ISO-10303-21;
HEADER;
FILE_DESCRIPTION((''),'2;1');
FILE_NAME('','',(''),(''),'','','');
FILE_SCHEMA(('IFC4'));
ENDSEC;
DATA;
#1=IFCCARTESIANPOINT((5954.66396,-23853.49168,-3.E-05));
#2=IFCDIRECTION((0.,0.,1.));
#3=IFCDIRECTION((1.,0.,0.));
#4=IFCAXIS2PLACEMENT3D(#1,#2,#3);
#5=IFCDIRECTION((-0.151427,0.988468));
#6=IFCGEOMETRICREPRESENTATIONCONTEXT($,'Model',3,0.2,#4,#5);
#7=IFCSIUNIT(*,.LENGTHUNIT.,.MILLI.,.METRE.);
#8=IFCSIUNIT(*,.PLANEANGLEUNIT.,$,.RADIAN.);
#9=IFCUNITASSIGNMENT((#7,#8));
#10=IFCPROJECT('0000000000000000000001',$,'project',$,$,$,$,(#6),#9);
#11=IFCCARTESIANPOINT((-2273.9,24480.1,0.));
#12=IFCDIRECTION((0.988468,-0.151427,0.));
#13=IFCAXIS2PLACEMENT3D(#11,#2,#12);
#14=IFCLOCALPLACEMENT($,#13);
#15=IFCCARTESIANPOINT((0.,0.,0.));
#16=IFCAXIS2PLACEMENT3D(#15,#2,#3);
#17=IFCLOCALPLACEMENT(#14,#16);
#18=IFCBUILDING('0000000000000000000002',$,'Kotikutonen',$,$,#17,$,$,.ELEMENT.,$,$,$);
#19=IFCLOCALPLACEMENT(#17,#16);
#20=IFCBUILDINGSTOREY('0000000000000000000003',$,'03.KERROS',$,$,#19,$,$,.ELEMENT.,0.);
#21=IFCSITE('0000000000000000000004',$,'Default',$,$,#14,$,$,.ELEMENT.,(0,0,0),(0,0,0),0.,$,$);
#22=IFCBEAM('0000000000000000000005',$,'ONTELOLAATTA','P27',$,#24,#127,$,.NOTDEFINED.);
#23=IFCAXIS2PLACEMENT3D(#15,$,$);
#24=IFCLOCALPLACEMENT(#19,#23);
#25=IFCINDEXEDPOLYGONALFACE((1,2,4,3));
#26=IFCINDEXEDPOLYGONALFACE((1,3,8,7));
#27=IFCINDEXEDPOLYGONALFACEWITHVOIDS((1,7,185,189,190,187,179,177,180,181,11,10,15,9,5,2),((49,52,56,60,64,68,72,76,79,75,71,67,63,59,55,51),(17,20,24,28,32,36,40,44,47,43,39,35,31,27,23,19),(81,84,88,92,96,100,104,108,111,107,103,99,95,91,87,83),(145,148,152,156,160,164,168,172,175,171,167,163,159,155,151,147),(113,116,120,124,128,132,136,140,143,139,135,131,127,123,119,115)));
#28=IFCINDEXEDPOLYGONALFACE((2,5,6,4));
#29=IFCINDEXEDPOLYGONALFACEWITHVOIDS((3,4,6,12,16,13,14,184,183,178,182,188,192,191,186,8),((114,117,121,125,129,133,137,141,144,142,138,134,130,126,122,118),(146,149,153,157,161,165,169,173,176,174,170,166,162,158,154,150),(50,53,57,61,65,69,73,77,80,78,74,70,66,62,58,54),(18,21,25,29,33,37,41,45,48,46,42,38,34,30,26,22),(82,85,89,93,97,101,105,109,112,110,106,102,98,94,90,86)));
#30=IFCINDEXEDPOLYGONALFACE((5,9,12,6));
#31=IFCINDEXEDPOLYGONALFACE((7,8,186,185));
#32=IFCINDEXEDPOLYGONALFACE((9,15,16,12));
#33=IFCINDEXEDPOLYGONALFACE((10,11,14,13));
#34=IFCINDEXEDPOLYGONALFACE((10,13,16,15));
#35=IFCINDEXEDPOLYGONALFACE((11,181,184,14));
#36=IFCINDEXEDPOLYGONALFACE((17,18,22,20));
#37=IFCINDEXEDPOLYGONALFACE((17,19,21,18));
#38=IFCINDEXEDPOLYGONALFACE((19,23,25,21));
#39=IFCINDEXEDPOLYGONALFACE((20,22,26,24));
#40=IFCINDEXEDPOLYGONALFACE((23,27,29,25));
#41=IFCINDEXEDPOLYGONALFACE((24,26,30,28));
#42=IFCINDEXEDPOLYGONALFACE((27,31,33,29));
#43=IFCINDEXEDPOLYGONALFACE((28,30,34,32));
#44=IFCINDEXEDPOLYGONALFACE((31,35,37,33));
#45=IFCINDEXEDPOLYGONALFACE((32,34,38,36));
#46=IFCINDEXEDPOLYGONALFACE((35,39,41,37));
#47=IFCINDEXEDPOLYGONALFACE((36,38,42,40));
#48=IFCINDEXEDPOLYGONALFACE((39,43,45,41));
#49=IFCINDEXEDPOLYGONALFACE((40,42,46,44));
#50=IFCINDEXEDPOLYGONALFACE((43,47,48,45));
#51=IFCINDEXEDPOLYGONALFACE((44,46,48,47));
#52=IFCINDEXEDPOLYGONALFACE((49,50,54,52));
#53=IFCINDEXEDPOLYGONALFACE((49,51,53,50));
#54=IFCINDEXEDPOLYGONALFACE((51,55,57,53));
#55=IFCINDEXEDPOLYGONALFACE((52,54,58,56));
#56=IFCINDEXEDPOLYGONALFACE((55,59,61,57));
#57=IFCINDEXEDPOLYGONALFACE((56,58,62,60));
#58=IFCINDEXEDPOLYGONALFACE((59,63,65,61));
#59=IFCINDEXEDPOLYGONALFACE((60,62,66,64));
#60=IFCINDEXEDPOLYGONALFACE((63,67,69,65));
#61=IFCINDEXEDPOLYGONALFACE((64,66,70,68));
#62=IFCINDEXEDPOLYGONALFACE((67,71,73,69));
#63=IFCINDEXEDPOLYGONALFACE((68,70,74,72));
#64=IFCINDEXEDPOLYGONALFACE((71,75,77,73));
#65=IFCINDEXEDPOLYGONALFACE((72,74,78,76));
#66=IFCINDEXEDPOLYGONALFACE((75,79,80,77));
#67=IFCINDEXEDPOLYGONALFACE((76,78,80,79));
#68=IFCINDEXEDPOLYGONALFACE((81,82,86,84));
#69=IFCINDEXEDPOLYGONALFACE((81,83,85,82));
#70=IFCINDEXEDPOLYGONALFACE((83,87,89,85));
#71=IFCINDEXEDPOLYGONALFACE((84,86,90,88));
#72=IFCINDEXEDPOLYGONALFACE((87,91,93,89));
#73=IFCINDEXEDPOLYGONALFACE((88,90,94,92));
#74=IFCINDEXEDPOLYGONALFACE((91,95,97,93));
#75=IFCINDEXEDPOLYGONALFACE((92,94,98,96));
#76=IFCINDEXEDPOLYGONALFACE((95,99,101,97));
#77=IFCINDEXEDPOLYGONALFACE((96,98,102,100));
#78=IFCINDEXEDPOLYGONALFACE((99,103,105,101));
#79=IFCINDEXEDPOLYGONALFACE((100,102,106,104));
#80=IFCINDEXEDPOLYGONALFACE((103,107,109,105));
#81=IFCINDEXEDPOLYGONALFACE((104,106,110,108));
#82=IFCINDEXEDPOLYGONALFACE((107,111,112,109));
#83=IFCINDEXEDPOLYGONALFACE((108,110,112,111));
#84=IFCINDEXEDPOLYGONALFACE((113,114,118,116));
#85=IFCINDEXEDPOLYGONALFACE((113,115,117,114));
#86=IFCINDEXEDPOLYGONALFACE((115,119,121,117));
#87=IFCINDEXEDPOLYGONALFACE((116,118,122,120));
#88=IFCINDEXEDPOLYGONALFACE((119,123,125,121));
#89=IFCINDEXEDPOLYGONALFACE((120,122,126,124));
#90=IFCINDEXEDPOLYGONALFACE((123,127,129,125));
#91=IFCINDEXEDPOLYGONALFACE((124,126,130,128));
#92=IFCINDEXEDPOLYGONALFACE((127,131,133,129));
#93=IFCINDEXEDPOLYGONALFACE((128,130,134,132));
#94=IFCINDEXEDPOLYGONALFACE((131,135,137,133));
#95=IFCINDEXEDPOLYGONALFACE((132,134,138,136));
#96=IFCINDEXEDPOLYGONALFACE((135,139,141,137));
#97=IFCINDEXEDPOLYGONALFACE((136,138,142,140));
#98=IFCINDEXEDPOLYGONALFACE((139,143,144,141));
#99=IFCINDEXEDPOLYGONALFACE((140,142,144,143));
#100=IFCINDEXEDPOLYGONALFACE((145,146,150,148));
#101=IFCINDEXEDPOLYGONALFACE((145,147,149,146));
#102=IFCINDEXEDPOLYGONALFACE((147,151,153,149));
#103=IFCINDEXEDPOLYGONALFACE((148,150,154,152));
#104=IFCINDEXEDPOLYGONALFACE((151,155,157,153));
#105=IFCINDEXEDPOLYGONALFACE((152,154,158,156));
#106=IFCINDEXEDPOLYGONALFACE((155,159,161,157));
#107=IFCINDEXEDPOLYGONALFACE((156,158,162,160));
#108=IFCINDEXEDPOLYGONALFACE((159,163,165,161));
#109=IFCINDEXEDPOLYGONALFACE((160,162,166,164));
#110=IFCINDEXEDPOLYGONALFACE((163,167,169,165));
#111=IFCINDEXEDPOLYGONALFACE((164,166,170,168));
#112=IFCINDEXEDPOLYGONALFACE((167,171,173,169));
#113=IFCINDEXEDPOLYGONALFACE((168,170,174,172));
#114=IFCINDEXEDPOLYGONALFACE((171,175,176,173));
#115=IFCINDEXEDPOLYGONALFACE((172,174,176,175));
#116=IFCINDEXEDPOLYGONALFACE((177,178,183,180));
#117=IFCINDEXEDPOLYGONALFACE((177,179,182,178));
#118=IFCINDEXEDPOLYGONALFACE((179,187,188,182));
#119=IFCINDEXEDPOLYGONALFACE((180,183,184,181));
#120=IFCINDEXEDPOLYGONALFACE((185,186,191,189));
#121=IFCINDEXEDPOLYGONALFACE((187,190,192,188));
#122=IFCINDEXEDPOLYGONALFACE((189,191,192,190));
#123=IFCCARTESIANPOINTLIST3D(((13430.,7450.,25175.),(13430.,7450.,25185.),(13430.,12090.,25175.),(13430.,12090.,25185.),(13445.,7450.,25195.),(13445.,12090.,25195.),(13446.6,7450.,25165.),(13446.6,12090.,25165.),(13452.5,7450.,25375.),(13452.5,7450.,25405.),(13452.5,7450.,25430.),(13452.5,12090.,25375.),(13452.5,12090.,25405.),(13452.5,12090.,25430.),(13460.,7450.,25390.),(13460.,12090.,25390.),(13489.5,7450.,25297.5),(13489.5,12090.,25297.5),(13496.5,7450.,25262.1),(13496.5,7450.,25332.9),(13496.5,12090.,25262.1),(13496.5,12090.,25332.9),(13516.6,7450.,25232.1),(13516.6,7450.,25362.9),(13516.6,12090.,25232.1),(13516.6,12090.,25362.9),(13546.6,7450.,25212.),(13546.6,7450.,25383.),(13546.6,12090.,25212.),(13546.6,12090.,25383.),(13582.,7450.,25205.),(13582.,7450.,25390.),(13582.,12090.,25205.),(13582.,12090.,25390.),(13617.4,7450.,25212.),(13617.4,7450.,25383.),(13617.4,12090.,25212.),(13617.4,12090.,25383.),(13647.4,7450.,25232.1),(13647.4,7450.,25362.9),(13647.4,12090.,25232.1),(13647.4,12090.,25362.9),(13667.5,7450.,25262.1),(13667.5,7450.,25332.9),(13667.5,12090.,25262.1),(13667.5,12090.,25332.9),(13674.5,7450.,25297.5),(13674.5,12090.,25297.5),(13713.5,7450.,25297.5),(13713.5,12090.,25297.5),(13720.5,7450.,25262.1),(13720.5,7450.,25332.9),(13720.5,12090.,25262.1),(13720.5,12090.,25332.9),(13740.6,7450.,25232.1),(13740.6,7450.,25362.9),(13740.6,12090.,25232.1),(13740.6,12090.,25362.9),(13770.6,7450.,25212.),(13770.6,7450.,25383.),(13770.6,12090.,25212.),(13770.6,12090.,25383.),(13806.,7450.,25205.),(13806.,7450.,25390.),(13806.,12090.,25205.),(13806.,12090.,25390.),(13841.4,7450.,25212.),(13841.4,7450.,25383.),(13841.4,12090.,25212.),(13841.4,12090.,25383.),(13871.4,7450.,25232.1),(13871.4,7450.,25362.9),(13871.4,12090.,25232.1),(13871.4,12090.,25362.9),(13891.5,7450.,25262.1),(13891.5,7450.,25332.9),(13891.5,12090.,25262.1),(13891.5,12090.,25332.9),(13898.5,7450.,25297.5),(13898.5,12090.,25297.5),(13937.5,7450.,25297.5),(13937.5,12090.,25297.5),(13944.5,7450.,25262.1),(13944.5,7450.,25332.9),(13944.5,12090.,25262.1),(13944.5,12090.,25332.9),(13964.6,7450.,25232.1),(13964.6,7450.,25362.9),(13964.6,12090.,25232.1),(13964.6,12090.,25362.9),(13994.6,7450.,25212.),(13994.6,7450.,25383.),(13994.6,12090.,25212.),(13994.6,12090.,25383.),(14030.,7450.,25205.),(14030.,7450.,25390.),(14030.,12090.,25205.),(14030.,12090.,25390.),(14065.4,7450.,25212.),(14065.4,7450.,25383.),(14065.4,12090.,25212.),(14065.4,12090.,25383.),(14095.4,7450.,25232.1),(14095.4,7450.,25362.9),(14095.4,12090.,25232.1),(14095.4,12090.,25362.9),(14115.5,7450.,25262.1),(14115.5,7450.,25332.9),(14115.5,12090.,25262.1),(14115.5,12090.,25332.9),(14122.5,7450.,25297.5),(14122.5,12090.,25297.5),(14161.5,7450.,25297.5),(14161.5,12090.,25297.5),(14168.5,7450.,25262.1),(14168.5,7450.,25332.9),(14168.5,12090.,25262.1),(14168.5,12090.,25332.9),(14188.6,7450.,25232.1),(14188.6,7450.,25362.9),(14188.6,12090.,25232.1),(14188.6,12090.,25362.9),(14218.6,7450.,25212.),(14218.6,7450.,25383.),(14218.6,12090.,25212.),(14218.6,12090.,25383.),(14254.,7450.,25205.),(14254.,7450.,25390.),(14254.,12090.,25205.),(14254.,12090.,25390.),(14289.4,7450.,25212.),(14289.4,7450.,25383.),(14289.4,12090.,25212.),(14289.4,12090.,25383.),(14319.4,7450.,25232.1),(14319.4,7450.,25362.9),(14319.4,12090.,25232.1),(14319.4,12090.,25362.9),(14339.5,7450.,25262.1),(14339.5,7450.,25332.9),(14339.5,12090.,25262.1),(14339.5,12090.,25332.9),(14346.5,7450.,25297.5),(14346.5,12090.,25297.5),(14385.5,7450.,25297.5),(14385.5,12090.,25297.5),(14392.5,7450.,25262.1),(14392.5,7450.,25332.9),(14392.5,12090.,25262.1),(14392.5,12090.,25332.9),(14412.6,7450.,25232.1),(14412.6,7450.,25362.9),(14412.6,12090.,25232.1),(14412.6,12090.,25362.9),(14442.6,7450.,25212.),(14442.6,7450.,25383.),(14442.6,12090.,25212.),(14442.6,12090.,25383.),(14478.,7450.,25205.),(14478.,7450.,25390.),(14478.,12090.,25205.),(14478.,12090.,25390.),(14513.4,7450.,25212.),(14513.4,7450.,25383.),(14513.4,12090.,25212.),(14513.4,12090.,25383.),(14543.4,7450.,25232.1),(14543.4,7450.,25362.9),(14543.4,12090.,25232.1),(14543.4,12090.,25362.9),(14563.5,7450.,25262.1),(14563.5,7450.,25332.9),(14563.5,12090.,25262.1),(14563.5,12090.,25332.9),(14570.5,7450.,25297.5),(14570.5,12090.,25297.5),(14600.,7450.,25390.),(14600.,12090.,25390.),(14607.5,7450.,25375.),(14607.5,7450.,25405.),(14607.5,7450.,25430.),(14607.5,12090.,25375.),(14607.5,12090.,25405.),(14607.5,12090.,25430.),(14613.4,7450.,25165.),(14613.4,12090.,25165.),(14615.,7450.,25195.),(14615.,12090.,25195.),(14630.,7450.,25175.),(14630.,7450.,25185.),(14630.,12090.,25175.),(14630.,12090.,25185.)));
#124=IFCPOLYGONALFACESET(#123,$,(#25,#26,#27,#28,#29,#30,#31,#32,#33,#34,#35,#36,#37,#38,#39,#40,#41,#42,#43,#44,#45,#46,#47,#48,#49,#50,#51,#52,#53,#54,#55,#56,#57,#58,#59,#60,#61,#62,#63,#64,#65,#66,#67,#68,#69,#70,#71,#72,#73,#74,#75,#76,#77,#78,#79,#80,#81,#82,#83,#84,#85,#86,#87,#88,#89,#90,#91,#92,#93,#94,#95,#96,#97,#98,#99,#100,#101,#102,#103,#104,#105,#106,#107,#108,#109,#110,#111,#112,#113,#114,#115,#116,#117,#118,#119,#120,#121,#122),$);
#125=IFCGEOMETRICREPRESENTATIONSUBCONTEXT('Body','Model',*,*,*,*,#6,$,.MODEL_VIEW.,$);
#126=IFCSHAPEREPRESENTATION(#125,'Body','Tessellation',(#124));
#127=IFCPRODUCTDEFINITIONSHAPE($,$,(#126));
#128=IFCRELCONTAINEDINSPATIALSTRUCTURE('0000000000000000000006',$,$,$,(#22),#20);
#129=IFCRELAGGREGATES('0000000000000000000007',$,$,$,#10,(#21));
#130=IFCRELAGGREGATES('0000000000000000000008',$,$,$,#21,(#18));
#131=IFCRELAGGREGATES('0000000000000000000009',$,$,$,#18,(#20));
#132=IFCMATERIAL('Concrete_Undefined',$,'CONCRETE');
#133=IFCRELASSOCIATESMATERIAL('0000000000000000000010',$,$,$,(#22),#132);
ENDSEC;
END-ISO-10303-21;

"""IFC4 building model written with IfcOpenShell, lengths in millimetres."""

from ifc_helpers import new_model, si_unit, direction, frame, origin_with_axes, place, context, subcontext, project, spatial, line, indexed_curve, outline, extrude, material, element, save


model = new_model("IFC4")

# Units and contexts
model_context = context("Model", 3, precision=0.2, world=frame((5954.66396, -23853.49168, -3e-05), z_axis=(0.0, 0.0, 1.0), x_axis=(1.0, 0.0, 0.0)), true_north=direction((-0.151427, 0.988468)))
body_context = subcontext(model_context, "Body", "Model", "MODEL_VIEW")
ifc_project = project(units=[si_unit("LENGTHUNIT", "METRE", prefix="MILLI"), si_unit("PLANEANGLEUNIT", "RADIAN")], contexts=[model_context])

# Site, building, storey
site_placement = place(None, frame((-2273.9, 24480.1, 0.0), z_axis=(0.0, 0.0, 1.0), x_axis=(0.988468, -0.151427, 0.0)))
site = spatial("IfcSite", under=ifc_project, at=site_placement, Name="Default", CompositionType="ELEMENT", RefLatitude=(0, 0, 0), RefLongitude=(0, 0, 0), RefElevation=0.0)
building_placement = place(site_placement, origin_with_axes())
building = spatial("IfcBuilding", under=site, at=building_placement, Name="Kotikutonen", CompositionType="ELEMENT")
storey_placement = place(building_placement, origin_with_axes())
storey = spatial("IfcBuildingStorey", under=building, at=storey_placement, Name="03.KERROS", CompositionType="ELEMENT", Elevation=0.0)

# Shared definitions
ifc_material_1 = material(Name="Concrete_Undefined", Category="CONCRETE")

# Beam
beam_1_placement = place(storey_placement, frame((14030.0, 12090.0, 25297.5), z_axis=(-1.0, 0.0, 0.0), x_axis=(0.0, -1.0, 0.0)))
element("IfcBeam", 1, at=beam_1_placement, inside=storey, material=ifc_material_1, Name="ONTELOLAATTA", Description="P27", PredefinedType="NOTDEFINED", context=body_context, shape_type="SolidModel", body=[
    extrude(outline(indexed_curve([(-600.0, -122.5), (-583.4, -132.5), (583.4, -132.5), (600.0, -122.5), (600.0, -112.5), (585.0, -102.5), (577.5, 77.5), (570.0, 92.5), (577.5, 107.5), (577.5, 132.5), (-577.5, 132.5), (-577.5, 107.5), (-570.0, 92.5), (-577.5, 77.5), (-585.0, -102.5), (-600.0, -112.5)], segments=[line(1, 2, 3, 4, 5, 6, 7, 8, 9, 10, 11, 12, 13, 14, 15, 16, 1)]), holes=[indexed_curve([(-448.0, -92.5), (-483.4, -85.5), (-513.4, -65.4), (-533.5, -35.4), (-540.5, 0.0), (-533.5, 35.4), (-513.4, 65.4), (-483.4, 85.5), (-448.0, 92.5), (-412.6, 85.5), (-382.6, 65.4), (-362.5, 35.4), (-355.5, 0.0), (-362.5, -35.4), (-382.6, -65.4), (-412.6, -85.5)], segments=[line(1, 2, 3, 4, 5, 6, 7, 8, 9, 10, 11, 12, 13, 14, 15, 16, 1)]), indexed_curve([(-224.0, -92.5), (-259.4, -85.5), (-289.4, -65.4), (-309.5, -35.4), (-316.5, 0.0), (-309.5, 35.4), (-289.4, 65.4), (-259.4, 85.5), (-224.0, 92.5), (-188.6, 85.5), (-158.6, 65.4), (-138.5, 35.4), (-131.5, 0.0), (-138.5, -35.4), (-158.6, -65.4), (-188.6, -85.5)], segments=[line(1, 2, 3, 4, 5, 6, 7, 8, 9, 10, 11, 12, 13, 14, 15, 16, 1)]), indexed_curve([(0.0, -92.5), (-35.4, -85.5), (-65.4, -65.4), (-85.5, -35.4), (-92.5, 0.0), (-85.5, 35.4), (-65.4, 65.4), (-35.4, 85.5), (0.0, 92.5), (35.4, 85.5), (65.4, 65.4), (85.5, 35.4), (92.5, 0.0), (85.5, -35.4), (65.4, -65.4), (35.4, -85.5)], segments=[line(1, 2, 3, 4, 5, 6, 7, 8, 9, 10, 11, 12, 13, 14, 15, 16, 1)]), indexed_curve([(224.0, -92.5), (188.6, -85.5), (158.6, -65.4), (138.5, -35.4), (131.5, 0.0), (138.5, 35.4), (158.6, 65.4), (188.6, 85.5), (224.0, 92.5), (259.4, 85.5), (289.4, 65.4), (309.5, 35.4), (316.5, 0.0), (309.5, -35.4), (289.4, -65.4), (259.4, -85.5)], segments=[line(1, 2, 3, 4, 5, 6, 7, 8, 9, 10, 11, 12, 13, 14, 15, 16, 1)]), indexed_curve([(448.0, -92.5), (412.6, -85.5), (382.6, -65.4), (362.5, -35.4), (355.5, 0.0), (362.5, 35.4), (382.6, 65.4), (412.6, 85.5), (448.0, 92.5), (483.4, 85.5), (513.4, 65.4), (533.5, 35.4), (540.5, 0.0), (533.5, -35.4), (513.4, -65.4), (483.4, -85.5)], segments=[line(1, 2, 3, 4, 5, 6, 7, 8, 9, 10, 11, 12, 13, 14, 15, 16, 1)])]), frame((0.0, 0.0, 0.0), z_axis=(-1.0, 0.0, 0.0), x_axis=(0.0, 0.0, 1.0)), (0.0, 0.0, -1.0), 4640.0),
])

save(model, "model.ifc")
